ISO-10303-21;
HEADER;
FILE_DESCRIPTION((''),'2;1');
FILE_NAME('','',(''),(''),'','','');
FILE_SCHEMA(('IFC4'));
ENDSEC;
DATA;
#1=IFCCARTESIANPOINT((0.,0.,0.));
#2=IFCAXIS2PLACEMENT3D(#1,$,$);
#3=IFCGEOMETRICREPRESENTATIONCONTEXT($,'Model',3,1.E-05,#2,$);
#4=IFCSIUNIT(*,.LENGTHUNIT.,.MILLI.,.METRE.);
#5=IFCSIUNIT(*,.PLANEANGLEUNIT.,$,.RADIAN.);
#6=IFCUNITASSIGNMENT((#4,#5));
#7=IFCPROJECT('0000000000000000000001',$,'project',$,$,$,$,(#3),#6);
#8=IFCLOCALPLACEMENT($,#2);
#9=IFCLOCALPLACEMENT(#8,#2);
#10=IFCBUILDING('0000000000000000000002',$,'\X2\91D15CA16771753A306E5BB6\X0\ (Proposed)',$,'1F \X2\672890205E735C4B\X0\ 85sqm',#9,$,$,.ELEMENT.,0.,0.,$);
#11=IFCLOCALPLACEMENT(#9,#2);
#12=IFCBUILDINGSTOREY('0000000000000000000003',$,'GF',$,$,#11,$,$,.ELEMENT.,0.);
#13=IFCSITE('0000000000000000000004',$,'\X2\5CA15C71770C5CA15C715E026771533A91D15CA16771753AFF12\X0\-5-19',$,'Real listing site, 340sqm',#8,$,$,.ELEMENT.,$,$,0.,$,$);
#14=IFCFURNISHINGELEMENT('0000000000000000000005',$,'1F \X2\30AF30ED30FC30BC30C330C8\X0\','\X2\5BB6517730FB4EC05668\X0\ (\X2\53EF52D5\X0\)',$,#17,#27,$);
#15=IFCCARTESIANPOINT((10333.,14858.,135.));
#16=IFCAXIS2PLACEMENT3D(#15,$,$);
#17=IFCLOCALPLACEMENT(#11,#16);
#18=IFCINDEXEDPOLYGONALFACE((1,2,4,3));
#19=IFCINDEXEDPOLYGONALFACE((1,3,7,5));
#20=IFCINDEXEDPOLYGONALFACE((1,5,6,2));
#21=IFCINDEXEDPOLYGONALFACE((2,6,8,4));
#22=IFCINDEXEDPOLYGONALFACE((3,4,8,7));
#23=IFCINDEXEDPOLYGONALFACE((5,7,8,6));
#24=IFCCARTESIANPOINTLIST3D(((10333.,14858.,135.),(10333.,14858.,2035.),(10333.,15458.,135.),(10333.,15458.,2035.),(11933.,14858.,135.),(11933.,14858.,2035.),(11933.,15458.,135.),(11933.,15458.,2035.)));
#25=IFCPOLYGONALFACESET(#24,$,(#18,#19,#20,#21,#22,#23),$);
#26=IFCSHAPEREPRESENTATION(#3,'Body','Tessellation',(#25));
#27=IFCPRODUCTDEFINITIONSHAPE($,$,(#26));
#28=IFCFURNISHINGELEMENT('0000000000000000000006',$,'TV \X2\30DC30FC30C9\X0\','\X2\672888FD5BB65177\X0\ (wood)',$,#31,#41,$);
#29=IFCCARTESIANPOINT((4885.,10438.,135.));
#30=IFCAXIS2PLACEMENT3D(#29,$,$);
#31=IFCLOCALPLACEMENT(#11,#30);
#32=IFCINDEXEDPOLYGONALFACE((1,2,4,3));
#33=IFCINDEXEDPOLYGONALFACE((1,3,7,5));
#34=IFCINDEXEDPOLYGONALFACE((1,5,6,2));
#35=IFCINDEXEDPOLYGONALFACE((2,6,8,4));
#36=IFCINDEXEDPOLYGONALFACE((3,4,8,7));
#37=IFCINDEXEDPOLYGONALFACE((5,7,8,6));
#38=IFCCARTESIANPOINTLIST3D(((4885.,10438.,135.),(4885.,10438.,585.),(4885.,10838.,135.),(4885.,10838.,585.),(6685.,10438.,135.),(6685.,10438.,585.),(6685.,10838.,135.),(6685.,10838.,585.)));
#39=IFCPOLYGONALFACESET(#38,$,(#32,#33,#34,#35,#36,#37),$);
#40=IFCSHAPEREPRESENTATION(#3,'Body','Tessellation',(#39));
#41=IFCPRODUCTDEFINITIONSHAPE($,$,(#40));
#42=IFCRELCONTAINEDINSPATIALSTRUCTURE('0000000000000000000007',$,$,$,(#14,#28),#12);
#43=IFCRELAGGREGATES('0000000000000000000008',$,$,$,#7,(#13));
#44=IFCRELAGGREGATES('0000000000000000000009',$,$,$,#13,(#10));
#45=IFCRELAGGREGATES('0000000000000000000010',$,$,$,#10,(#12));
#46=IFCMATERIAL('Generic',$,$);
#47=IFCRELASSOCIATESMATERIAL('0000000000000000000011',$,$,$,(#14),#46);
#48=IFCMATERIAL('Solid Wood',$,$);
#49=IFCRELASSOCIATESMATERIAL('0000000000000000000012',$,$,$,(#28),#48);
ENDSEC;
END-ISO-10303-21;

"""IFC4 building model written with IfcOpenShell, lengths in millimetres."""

from ifc_helpers import new_model, si_unit, frame, frame_2d, origin, place, context, project, spatial, rectangle, extrude, material, element, save


model = new_model("IFC4")

# Units and contexts
model_context = context("Model", 3, precision=1e-05, world=origin())
ifc_project = project(units=[si_unit("LENGTHUNIT", "METRE", prefix="MILLI"), si_unit("PLANEANGLEUNIT", "RADIAN")], contexts=[model_context])

# Site, building, storey
site_placement = place(None, origin())
site = spatial("IfcSite", under=ifc_project, at=site_placement, Name="岡山県岡山市東区金岡東町２-5-19", ObjectType="Real listing site, 340sqm", CompositionType="ELEMENT", RefElevation=0.0)
building_placement = place(site_placement, origin())
building = spatial("IfcBuilding", under=site, at=building_placement, Name="金岡東町の家 (Proposed)", ObjectType="1F 木造平屋 85sqm", CompositionType="ELEMENT", ElevationOfRefHeight=0.0, ElevationOfTerrain=0.0)
storey_placement = place(building_placement, origin())
storey = spatial("IfcBuildingStorey", under=building, at=storey_placement, Name="GF", CompositionType="ELEMENT", Elevation=0.0)

# Shared definitions
ifc_material_1 = material(Name="Solid Wood")

# Shared definitions
ifc_material_2 = material(Name="Generic")

# Furnishing elements
furnishing_1_placement = place(storey_placement, frame((10333.0, 14858.0, 135.0)))
element("IfcFurnishingElement", 1, at=furnishing_1_placement, inside=storey, material=ifc_material_2, Name="1F クローゼット", Description="家具・什器 (可動)", context=model_context, shape_type="SweptSolid", body=[
    extrude(rectangle(XDim=1600.0, YDim=600.0, at=frame_2d((800.0, 300.0))), frame((10333.0, 14858.0, 135.0)), (0.0, 0.0, 1.0), 1900.0),
])
furnishing_2_placement = place(storey_placement, frame((4885.0, 10438.0, 135.0)))
element("IfcFurnishingElement", 2, at=furnishing_2_placement, inside=storey, material=ifc_material_1, Name="TV ボード", Description="木製家具 (wood)", context=model_context, shape_type="SweptSolid", body=[
    extrude(rectangle(XDim=1800.0, YDim=400.0, at=frame_2d((900.0, 200.0))), frame((4885.0, 10438.0, 135.0)), (0.0, 0.0, 1.0), 450.0),
])

save(model, "model.ifc")
